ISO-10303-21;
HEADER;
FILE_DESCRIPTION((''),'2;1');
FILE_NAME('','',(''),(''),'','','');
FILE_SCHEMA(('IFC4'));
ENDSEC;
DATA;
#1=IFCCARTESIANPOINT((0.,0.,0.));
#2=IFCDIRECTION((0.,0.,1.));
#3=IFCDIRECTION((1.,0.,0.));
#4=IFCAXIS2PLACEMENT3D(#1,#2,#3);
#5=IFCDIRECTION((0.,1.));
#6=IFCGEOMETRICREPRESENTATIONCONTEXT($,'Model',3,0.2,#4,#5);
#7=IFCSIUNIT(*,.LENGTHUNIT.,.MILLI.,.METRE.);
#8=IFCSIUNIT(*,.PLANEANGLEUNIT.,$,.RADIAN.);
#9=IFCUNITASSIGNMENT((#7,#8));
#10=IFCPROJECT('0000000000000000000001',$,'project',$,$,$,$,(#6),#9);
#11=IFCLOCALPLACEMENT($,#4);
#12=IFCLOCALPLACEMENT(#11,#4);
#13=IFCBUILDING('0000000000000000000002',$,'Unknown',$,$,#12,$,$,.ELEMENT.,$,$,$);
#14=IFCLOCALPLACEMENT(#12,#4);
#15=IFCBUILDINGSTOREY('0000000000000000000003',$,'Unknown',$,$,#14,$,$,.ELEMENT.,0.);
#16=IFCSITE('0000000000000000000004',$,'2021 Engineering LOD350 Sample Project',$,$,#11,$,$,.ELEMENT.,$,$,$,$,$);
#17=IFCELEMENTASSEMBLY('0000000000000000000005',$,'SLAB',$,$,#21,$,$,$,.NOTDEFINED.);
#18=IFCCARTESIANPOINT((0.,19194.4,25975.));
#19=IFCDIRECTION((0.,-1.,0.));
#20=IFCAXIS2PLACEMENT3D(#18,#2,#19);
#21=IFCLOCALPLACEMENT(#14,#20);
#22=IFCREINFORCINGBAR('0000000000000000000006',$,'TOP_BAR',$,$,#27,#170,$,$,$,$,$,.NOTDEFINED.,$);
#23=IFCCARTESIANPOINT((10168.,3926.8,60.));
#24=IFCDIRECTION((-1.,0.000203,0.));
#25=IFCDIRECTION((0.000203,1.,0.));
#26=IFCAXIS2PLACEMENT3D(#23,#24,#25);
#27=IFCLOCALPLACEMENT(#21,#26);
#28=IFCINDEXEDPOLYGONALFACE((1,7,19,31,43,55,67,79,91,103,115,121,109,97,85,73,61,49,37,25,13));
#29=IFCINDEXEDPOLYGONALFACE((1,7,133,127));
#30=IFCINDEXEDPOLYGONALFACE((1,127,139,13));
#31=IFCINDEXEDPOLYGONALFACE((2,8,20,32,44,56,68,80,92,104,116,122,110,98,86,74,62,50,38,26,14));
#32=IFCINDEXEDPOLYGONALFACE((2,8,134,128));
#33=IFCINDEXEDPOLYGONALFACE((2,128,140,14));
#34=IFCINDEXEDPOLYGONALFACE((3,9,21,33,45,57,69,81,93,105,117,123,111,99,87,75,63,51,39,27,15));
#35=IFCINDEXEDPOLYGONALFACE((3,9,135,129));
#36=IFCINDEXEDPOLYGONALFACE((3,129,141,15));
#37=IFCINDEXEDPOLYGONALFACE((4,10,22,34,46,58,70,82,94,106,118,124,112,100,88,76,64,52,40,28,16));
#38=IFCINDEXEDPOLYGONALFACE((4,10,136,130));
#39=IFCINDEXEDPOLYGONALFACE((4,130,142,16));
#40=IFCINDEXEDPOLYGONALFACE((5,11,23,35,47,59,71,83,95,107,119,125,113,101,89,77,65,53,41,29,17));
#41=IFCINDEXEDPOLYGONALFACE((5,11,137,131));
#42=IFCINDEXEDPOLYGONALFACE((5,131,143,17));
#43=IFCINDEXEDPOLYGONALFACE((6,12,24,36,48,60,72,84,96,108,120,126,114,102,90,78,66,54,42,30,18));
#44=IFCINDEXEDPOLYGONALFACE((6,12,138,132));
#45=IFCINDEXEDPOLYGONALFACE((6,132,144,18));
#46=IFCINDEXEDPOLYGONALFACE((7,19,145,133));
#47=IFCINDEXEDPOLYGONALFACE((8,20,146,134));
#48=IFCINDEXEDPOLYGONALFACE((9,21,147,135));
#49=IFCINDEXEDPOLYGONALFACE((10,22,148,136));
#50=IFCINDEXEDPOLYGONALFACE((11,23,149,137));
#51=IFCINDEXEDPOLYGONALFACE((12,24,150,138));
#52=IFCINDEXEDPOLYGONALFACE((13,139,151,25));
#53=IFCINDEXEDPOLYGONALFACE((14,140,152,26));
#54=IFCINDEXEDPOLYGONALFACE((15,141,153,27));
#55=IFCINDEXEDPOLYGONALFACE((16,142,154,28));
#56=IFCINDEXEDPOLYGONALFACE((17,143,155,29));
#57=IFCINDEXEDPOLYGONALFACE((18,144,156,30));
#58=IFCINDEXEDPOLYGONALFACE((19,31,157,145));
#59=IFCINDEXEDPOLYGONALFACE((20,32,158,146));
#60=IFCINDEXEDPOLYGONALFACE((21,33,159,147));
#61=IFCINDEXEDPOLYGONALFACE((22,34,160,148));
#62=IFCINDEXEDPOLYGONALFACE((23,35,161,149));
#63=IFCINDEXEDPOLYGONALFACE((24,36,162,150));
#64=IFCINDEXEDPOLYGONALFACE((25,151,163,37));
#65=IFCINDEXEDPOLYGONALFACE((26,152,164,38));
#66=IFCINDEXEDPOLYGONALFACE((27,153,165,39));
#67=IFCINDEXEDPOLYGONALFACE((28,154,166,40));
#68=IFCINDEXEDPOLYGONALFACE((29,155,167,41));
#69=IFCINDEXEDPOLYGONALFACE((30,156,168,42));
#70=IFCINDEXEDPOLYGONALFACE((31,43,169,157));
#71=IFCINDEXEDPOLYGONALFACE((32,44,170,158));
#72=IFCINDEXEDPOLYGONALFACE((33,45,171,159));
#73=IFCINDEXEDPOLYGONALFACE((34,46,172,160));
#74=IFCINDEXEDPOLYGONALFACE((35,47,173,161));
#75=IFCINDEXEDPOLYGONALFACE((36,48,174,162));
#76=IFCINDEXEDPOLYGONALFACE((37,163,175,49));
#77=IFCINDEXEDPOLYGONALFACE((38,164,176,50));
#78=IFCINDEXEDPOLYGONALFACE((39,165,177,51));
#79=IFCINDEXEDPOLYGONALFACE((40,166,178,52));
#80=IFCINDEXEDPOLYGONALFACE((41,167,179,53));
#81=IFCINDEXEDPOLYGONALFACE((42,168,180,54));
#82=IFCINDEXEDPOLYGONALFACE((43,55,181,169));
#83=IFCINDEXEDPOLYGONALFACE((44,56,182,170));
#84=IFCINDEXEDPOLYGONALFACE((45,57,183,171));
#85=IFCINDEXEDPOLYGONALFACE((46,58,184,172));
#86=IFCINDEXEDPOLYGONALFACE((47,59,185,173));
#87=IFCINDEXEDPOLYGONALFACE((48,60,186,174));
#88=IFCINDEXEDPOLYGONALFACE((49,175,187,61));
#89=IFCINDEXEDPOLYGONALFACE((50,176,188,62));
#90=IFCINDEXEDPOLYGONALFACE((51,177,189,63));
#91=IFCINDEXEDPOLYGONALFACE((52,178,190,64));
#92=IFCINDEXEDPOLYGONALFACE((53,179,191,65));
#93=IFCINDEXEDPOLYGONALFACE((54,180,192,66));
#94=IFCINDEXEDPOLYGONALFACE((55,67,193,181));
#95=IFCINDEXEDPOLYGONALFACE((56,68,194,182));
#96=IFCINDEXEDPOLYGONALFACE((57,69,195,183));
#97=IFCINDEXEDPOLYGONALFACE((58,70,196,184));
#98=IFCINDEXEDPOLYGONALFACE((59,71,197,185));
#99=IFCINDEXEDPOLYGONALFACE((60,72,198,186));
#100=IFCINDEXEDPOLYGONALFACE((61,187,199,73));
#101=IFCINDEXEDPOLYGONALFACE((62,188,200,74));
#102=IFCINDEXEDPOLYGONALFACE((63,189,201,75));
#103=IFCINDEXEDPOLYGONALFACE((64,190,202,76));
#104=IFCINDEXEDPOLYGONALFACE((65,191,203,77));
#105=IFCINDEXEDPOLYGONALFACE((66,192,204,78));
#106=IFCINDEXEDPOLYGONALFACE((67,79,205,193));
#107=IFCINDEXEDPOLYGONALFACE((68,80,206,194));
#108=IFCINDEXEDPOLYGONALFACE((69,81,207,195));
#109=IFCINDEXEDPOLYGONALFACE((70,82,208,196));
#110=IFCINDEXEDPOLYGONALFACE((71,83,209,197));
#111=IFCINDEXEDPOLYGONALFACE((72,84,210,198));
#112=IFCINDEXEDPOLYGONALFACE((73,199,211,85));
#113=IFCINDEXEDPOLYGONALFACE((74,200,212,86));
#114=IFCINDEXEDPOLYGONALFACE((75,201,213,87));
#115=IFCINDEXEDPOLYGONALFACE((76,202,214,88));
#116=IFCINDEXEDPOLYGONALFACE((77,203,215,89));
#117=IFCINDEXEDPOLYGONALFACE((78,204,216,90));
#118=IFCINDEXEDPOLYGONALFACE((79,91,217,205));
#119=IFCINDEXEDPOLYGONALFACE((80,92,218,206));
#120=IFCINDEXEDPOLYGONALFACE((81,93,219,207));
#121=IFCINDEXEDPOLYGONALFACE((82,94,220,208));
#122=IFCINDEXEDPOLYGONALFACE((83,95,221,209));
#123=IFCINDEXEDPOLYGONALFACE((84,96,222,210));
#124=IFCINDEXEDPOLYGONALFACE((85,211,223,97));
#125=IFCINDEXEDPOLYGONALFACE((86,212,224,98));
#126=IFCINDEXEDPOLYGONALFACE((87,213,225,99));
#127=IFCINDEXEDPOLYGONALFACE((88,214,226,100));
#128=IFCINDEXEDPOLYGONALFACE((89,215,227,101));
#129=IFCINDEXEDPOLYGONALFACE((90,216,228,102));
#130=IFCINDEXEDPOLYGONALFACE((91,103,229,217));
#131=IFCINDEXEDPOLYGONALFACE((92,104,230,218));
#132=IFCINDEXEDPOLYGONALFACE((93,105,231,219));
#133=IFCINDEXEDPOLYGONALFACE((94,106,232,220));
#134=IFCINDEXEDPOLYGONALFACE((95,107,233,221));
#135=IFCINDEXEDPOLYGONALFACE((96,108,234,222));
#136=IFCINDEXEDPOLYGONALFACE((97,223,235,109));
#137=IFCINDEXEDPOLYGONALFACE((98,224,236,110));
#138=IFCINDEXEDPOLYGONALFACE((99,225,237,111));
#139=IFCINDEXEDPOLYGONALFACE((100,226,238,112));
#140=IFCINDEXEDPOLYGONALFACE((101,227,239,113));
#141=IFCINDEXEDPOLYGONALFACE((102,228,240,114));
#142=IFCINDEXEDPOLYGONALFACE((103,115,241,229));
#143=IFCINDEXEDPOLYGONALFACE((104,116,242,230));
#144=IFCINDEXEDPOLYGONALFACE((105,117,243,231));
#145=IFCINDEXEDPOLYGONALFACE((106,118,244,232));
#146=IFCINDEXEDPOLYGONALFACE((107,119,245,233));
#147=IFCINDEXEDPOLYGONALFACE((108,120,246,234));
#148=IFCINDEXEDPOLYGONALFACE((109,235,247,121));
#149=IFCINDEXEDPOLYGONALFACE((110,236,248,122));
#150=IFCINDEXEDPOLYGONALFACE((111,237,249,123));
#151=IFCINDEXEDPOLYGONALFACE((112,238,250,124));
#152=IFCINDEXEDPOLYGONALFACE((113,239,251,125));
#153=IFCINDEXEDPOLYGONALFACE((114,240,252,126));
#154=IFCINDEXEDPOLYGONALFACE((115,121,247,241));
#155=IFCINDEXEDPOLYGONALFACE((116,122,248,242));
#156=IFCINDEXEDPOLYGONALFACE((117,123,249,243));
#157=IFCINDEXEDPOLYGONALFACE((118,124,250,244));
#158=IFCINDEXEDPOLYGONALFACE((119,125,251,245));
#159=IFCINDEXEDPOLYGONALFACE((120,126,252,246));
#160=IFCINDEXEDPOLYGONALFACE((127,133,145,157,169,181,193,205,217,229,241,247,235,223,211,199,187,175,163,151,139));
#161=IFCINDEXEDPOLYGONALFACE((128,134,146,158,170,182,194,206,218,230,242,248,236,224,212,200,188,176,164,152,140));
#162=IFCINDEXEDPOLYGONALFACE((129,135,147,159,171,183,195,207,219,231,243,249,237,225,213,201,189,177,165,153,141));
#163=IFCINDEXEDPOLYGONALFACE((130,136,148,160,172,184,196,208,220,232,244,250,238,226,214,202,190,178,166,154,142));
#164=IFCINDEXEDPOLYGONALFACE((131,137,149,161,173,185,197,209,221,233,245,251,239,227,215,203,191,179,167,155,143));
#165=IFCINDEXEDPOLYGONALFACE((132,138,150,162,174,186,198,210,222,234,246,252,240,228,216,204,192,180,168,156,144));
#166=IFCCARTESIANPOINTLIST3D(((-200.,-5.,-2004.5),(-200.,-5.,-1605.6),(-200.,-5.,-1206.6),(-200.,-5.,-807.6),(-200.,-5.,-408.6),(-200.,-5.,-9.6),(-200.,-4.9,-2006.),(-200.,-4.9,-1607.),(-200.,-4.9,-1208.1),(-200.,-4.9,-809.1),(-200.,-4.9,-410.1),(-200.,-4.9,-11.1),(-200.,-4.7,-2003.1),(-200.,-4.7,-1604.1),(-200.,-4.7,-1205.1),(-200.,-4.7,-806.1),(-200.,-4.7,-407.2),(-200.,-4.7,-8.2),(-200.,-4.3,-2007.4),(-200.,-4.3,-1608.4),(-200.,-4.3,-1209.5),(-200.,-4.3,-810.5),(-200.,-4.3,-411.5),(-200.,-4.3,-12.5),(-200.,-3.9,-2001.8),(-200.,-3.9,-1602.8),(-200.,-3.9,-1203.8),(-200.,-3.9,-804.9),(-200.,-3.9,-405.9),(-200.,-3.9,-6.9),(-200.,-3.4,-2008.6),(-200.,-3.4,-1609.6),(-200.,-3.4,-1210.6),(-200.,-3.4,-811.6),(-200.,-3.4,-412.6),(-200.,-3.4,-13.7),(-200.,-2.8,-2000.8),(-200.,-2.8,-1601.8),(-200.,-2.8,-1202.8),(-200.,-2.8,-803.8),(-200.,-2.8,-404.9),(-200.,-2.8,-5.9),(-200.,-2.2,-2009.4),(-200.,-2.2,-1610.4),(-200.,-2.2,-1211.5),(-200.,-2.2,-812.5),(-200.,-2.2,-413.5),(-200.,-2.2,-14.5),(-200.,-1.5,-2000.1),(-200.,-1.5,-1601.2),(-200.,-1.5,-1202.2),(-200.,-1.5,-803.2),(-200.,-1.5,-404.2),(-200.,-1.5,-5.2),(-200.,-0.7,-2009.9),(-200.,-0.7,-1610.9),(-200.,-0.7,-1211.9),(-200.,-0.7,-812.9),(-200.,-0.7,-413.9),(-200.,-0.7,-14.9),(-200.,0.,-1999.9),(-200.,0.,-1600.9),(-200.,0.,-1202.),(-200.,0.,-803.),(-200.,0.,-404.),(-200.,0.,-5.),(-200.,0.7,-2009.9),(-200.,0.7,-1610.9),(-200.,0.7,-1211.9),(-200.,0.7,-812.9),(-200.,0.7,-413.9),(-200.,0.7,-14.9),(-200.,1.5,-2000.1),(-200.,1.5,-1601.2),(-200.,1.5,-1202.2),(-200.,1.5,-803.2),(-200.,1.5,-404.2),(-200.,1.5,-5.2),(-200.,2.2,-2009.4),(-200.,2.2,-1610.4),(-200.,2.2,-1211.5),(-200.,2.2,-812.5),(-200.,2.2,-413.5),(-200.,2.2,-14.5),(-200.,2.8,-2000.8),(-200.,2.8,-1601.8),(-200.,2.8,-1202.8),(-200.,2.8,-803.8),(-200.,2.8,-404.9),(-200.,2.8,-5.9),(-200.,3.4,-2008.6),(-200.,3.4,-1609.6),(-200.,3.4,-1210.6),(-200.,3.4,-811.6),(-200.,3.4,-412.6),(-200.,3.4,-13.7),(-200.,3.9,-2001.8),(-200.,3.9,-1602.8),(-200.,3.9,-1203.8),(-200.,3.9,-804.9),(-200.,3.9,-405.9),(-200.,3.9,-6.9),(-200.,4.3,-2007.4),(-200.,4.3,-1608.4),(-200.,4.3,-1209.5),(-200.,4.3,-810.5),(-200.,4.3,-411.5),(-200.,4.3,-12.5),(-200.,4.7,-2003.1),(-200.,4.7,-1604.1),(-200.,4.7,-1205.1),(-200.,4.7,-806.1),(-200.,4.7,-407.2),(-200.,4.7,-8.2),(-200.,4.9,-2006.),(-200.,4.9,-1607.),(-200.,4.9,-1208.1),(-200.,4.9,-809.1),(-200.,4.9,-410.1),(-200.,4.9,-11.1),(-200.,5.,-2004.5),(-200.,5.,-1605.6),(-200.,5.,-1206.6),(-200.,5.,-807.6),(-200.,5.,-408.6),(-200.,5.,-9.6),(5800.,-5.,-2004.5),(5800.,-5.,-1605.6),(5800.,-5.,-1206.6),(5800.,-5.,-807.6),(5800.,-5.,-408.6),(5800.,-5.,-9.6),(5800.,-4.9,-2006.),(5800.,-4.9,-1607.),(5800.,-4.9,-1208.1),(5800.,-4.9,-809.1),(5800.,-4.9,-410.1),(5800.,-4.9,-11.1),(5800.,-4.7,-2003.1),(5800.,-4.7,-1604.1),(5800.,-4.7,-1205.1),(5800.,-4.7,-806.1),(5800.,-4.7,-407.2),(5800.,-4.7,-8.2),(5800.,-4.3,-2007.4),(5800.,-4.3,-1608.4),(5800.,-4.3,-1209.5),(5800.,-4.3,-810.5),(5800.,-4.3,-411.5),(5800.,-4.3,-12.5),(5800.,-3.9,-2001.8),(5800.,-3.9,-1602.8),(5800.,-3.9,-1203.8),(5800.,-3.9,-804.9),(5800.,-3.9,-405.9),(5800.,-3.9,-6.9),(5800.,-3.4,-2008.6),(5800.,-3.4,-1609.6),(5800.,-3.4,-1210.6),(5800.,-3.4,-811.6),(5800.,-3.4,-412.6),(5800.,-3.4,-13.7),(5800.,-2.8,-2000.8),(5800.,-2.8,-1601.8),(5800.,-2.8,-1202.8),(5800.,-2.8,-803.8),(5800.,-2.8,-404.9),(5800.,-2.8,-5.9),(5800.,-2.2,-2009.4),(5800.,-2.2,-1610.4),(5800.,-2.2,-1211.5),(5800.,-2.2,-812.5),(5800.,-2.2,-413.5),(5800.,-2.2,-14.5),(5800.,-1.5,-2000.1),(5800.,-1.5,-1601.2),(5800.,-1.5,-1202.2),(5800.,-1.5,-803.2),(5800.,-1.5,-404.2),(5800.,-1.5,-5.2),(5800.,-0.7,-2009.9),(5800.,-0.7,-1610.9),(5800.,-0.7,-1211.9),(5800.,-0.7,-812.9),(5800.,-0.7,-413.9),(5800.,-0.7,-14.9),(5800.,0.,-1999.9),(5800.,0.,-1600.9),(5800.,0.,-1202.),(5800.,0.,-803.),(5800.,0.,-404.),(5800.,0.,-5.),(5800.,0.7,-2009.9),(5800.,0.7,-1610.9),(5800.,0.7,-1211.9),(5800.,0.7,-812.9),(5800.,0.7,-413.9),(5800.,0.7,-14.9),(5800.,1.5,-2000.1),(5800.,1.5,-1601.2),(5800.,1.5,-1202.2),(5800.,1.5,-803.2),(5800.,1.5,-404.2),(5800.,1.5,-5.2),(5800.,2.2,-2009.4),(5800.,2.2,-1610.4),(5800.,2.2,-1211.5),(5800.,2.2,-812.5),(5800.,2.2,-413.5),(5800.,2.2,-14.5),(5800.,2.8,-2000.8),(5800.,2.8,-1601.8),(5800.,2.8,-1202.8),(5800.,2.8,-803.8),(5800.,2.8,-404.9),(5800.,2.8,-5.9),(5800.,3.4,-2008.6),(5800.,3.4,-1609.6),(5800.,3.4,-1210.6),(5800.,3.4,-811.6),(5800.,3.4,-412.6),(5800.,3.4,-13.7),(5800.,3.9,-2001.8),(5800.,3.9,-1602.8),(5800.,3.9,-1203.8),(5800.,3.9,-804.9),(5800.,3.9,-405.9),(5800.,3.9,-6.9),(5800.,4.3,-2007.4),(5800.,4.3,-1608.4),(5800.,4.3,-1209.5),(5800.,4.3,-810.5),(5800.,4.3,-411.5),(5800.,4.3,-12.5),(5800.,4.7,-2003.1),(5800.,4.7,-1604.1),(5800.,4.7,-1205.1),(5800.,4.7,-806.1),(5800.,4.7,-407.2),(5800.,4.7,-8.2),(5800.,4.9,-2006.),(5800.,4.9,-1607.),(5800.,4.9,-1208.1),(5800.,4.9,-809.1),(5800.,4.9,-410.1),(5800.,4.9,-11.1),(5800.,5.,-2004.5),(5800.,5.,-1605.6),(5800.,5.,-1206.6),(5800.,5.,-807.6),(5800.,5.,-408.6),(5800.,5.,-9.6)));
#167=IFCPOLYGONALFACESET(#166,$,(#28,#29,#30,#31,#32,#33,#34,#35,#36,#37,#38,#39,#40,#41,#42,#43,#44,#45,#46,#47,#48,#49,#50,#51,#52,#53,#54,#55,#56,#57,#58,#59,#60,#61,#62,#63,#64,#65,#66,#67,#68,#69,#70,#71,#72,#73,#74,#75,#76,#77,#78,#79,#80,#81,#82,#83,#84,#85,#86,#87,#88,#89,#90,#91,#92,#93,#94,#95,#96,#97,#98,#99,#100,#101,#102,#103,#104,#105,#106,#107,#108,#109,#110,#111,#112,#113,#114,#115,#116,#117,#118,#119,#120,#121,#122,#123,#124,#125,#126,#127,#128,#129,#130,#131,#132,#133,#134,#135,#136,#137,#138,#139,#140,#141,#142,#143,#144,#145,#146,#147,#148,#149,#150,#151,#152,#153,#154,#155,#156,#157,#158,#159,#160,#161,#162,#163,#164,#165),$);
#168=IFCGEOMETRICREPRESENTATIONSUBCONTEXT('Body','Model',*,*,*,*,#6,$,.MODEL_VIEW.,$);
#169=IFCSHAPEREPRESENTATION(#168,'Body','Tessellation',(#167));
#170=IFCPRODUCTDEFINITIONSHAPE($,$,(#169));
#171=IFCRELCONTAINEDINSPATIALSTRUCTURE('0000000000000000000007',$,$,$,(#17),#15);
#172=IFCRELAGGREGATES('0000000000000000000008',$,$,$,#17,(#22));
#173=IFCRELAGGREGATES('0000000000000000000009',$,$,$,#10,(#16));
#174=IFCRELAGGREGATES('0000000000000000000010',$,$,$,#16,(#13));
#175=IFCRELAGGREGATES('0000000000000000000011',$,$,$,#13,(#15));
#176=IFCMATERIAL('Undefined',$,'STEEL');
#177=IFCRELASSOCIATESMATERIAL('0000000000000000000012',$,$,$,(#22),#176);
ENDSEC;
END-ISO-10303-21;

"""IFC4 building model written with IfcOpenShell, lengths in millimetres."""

from ifc_helpers import new_model, entity, si_unit, direction, frame, origin_with_axes, place, context, subcontext, project, spatial, source, transform, mapped, material, element, aggregate, save


model = new_model("IFC4")

# Units and contexts
model_context = context("Model", 3, precision=0.2, world=origin_with_axes(), true_north=direction((0.0, 1.0)))
body_context = subcontext(model_context, "Body", "Model", "MODEL_VIEW")
ifc_project = project(units=[si_unit("LENGTHUNIT", "METRE", prefix="MILLI"), si_unit("PLANEANGLEUNIT", "RADIAN")], contexts=[model_context])

# Site, building, storey
site_placement = place(None, origin_with_axes())
site = spatial("IfcSite", under=ifc_project, at=site_placement, Name="2021 Engineering LOD350 Sample Project", CompositionType="ELEMENT")
building_placement = place(site_placement, origin_with_axes())
building = spatial("IfcBuilding", under=site, at=building_placement, Name="Unknown", CompositionType="ELEMENT")
storey_placement = place(building_placement, origin_with_axes())
storey = spatial("IfcBuildingStorey", under=building, at=storey_placement, Name="Unknown", CompositionType="ELEMENT", Elevation=0.0)

# Element assembly, reinforcing bar
assembly_1_placement = place(storey_placement, frame((0.0, 19194.4, 25975.0), z_axis=(0.0, 0.0, 1.0), x_axis=(0.0, -1.0, 0.0)))
assembly_1 = element("IfcElementAssembly", 1, at=assembly_1_placement, inside=storey, Name="SLAB", PredefinedType="NOTDEFINED")
ifc_material_1 = material(Name="Undefined", Category="STEEL")
shared_shape_1 = source(origin_with_axes(), body_context, "Body", "AdvancedSweptSolid", [
    entity("IfcSweptDiskSolid", entity("IfcIndexedPolyCurve", entity("IfcCartesianPointList3D", [[-200.0, 0.0, -10.0], [5800.0, 0.0, -10.0]]), [entity("IfcLineIndex", [1, 2])]), 5.0),
])
reinforcing_bar_1_placement = place(assembly_1_placement, frame((10168.0, 3926.8, 60.0), z_axis=(-1.0, 0.000203, 0.0), x_axis=(0.000203, 1.0, 0.0)))
reinforcing_bar_1 = element("IfcReinforcingBar", 2, at=reinforcing_bar_1_placement, material=ifc_material_1, Name="TOP_BAR", PredefinedType="NOTDEFINED", context=body_context, shape_type="MappedRepresentation", body=[
    mapped(shared_shape_1, transform((0.0, 0.0, 0.0))),
    mapped(shared_shape_1, transform((0.0, 0.0, -399.0))),
    mapped(shared_shape_1, transform((0.0, 0.0, -798.0))),
    mapped(shared_shape_1, transform((0.0, 0.0, -1197.0))),
    mapped(shared_shape_1, transform((0.0, 0.0, -1595.9))),
    mapped(shared_shape_1, transform((0.0, 0.0, -1994.9))),
])

aggregate(assembly_1, [reinforcing_bar_1])

save(model, "model.ifc")
